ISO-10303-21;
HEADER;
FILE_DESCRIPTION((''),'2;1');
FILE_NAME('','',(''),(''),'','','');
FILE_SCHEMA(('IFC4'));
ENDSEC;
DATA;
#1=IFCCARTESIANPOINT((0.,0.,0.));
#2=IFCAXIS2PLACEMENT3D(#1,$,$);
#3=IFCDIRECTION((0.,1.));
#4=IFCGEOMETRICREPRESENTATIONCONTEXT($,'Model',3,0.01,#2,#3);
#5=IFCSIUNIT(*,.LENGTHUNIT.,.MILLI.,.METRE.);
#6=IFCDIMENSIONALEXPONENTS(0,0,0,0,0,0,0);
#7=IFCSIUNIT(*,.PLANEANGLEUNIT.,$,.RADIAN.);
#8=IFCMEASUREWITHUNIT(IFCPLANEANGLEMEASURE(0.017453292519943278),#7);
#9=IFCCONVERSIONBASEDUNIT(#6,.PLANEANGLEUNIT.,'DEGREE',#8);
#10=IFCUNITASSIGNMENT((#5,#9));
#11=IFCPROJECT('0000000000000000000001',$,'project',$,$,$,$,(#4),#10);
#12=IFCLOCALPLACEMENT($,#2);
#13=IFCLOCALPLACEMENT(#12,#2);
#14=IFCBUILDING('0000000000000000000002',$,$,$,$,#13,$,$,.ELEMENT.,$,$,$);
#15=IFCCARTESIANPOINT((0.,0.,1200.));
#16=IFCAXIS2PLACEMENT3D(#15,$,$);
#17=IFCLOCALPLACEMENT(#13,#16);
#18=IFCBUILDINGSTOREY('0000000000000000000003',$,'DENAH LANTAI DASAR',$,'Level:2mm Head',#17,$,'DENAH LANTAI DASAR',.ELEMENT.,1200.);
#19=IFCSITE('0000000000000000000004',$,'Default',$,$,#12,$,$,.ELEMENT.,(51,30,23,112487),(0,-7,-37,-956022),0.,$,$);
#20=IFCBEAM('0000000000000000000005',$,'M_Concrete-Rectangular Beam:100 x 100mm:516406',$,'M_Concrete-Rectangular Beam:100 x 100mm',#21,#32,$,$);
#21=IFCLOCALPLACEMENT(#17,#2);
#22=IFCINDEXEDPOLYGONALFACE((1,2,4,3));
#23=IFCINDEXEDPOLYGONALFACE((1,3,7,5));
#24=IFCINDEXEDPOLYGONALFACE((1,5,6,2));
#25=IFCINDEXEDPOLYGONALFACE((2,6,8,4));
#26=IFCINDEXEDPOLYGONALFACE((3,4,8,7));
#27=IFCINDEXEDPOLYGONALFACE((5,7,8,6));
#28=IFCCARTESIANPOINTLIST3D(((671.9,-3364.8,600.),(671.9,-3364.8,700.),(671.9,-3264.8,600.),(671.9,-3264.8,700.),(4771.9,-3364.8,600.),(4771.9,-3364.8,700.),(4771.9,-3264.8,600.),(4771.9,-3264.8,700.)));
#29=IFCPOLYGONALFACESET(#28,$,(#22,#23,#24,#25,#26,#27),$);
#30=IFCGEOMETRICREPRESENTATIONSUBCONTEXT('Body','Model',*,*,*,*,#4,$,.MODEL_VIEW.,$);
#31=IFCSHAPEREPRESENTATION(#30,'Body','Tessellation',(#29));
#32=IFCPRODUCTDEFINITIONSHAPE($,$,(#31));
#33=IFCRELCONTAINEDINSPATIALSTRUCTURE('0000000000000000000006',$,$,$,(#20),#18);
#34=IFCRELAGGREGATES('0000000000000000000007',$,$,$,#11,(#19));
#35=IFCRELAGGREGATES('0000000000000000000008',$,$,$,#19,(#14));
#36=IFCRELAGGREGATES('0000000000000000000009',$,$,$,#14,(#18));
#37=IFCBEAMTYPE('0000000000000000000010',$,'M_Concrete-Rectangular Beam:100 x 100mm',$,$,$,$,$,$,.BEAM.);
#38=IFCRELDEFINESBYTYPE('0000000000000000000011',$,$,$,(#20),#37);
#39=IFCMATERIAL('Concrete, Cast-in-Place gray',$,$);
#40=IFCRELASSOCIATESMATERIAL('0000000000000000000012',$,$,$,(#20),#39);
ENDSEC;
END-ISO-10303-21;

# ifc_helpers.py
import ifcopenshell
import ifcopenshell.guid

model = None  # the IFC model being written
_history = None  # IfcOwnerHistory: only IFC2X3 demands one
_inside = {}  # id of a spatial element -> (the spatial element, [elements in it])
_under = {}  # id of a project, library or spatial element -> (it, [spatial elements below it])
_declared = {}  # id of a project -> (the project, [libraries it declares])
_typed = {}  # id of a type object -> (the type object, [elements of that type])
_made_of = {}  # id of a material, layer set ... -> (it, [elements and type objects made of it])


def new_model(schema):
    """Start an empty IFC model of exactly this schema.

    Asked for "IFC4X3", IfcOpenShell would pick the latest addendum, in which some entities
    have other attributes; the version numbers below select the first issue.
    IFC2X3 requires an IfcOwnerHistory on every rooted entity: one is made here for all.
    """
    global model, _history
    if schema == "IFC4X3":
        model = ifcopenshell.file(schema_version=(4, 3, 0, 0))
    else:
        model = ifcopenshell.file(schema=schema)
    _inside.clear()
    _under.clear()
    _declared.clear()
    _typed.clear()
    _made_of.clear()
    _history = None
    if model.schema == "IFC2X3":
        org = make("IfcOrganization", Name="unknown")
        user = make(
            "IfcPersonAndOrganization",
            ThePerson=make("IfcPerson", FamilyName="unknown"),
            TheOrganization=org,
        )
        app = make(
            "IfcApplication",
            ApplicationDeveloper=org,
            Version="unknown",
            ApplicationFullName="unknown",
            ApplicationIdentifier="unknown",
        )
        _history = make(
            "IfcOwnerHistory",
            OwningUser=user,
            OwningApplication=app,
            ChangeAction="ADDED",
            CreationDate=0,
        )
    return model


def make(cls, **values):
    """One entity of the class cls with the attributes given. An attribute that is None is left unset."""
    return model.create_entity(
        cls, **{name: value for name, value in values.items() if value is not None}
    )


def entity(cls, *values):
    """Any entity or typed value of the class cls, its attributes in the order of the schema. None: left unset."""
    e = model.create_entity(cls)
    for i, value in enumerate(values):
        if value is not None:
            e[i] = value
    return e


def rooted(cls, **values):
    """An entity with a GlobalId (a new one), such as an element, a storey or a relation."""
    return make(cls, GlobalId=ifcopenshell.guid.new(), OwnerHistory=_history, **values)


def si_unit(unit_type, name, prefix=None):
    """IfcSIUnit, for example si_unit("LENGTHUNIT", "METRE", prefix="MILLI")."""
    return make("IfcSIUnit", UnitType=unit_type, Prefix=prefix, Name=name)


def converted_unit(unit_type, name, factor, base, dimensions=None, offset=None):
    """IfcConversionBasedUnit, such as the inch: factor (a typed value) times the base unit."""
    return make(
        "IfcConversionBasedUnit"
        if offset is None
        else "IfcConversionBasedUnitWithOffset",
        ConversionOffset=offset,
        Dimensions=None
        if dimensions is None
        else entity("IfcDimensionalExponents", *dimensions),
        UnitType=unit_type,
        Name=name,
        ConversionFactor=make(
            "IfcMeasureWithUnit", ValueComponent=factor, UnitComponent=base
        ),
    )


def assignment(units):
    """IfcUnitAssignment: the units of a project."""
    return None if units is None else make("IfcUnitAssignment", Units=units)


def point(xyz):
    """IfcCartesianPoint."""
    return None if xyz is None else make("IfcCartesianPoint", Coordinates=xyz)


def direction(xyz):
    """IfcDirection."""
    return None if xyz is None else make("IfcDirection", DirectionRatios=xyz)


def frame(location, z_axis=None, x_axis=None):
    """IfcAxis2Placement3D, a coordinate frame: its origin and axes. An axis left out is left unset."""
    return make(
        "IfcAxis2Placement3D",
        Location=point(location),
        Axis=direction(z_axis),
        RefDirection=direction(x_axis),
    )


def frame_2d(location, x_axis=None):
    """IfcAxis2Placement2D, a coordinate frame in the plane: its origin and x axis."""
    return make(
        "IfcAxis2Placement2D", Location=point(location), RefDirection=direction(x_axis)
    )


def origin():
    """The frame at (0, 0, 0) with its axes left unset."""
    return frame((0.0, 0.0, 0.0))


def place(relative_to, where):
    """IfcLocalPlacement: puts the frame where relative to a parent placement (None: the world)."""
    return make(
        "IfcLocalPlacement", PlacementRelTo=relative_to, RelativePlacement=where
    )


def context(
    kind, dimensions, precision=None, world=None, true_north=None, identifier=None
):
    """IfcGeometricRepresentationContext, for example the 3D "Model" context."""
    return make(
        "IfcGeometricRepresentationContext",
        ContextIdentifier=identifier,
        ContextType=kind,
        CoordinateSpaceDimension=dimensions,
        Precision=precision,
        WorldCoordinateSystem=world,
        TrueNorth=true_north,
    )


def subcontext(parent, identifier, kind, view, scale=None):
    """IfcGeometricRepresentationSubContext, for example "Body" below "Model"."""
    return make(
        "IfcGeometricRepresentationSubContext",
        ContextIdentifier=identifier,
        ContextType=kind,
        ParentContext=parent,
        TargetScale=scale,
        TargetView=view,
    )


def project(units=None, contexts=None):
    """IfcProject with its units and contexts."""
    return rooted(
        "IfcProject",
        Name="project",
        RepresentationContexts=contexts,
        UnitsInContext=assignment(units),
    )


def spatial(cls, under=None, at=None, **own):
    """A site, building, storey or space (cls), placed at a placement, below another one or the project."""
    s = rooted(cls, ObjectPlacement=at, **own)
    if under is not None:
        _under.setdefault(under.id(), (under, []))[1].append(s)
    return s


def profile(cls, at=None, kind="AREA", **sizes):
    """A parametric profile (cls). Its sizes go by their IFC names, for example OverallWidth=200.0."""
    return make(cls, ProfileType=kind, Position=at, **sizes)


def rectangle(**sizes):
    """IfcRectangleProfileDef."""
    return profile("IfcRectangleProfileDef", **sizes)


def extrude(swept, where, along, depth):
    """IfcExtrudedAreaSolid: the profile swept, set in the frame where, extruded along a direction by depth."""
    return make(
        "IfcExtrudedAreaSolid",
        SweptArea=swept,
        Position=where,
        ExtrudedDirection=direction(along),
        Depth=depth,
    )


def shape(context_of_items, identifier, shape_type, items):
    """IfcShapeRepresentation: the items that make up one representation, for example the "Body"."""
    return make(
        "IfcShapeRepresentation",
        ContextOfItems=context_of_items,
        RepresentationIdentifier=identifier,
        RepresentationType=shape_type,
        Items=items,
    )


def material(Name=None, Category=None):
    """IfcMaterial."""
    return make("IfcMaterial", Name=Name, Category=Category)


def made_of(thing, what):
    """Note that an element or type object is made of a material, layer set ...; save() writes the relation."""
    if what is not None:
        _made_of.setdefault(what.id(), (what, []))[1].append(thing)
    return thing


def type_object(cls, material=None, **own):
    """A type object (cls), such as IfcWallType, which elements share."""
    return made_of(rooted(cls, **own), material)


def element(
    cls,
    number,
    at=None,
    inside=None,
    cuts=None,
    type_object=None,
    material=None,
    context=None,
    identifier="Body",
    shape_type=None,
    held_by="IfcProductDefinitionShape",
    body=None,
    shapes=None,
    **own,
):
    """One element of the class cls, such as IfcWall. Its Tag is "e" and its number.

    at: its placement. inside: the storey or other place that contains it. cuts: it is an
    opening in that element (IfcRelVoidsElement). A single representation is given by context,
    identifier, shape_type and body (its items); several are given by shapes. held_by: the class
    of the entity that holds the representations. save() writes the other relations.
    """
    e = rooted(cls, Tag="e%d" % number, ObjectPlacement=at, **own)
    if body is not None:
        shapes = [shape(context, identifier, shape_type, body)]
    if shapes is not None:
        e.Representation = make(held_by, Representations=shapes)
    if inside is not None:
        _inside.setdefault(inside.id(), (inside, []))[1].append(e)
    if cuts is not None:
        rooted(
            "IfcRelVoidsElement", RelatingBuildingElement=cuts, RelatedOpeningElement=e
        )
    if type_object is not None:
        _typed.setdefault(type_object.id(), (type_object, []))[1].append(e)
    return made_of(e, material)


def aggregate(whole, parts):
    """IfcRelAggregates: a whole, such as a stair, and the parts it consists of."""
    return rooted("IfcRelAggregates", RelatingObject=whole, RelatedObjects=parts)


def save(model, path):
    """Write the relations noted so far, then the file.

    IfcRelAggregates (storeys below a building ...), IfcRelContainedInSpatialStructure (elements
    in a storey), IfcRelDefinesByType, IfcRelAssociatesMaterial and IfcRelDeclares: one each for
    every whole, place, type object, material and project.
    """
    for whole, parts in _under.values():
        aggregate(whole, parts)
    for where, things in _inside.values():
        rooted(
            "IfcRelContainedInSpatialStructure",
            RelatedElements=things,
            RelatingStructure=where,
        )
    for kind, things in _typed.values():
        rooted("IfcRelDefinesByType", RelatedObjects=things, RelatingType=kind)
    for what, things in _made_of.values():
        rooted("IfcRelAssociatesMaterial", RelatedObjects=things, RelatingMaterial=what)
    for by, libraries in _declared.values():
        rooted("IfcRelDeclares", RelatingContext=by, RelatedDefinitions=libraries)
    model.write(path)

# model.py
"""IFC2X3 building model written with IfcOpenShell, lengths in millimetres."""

from ifc_helpers import new_model, entity, si_unit, converted_unit, direction, frame, frame_2d, origin, place, context, subcontext, project, spatial, rectangle, extrude, material, type_object, element, save


model = new_model("IFC2X3")

# Units and contexts
model_context = context("Model", 3, precision=0.01, world=origin(), true_north=direction((0.0, 1.0)))
body_context = subcontext(model_context, "Body", "Model", "MODEL_VIEW")
ifc_project = project(units=[si_unit("LENGTHUNIT", "METRE", prefix="MILLI"), converted_unit("PLANEANGLEUNIT", "DEGREE", entity("IfcPlaneAngleMeasure", 0.017453292519943278), si_unit("PLANEANGLEUNIT", "RADIAN"), dimensions=[0, 0, 0, 0, 0, 0, 0])], contexts=[model_context])

# Site, building, storey
site_placement = place(None, origin())
site = spatial("IfcSite", under=ifc_project, at=site_placement, Name="Default", CompositionType="ELEMENT", RefLatitude=(51, 30, 23, 112487), RefLongitude=(0, -7, -37, -956022), RefElevation=0.0)
building_placement = place(site_placement, origin())
building = spatial("IfcBuilding", under=site, at=building_placement, CompositionType="ELEMENT")
storey_placement = place(building_placement, frame((0.0, 0.0, 1200.0)))
storey = spatial("IfcBuildingStorey", under=building, at=storey_placement, Name="DENAH LANTAI DASAR", ObjectType="Level:2mm Head", LongName="DENAH LANTAI DASAR", CompositionType="ELEMENT", Elevation=1200.0)

# Beam
ifc_material_1 = material(Name="Concrete, Cast-in-Place gray")
beam_type = type_object("IfcBeamType", Name="M_Concrete-Rectangular Beam:100 x 100mm", PredefinedType="BEAM")
beam_placement = place(storey_placement, frame((571.9, -3314.8, 700.0)))
element("IfcBeam", 1, at=beam_placement, inside=storey, type_object=beam_type, material=ifc_material_1, Name="M_Concrete-Rectangular Beam:100 x 100mm:516406", ObjectType="M_Concrete-Rectangular Beam:100 x 100mm", context=body_context, shape_type="SweptSolid", body=[
    extrude(rectangle(XDim=100.0, YDim=100.0, at=frame_2d((0.0, 0.0), x_axis=(1.0, 0.0))), frame((100.0, 0.0, -50.0), z_axis=(1.0, 0.0, 0.0), x_axis=(0.0, 0.0, -1.0)), (0.0, 0.0, 1.0), 4100.0),
])

save(model, "model.ifc")
